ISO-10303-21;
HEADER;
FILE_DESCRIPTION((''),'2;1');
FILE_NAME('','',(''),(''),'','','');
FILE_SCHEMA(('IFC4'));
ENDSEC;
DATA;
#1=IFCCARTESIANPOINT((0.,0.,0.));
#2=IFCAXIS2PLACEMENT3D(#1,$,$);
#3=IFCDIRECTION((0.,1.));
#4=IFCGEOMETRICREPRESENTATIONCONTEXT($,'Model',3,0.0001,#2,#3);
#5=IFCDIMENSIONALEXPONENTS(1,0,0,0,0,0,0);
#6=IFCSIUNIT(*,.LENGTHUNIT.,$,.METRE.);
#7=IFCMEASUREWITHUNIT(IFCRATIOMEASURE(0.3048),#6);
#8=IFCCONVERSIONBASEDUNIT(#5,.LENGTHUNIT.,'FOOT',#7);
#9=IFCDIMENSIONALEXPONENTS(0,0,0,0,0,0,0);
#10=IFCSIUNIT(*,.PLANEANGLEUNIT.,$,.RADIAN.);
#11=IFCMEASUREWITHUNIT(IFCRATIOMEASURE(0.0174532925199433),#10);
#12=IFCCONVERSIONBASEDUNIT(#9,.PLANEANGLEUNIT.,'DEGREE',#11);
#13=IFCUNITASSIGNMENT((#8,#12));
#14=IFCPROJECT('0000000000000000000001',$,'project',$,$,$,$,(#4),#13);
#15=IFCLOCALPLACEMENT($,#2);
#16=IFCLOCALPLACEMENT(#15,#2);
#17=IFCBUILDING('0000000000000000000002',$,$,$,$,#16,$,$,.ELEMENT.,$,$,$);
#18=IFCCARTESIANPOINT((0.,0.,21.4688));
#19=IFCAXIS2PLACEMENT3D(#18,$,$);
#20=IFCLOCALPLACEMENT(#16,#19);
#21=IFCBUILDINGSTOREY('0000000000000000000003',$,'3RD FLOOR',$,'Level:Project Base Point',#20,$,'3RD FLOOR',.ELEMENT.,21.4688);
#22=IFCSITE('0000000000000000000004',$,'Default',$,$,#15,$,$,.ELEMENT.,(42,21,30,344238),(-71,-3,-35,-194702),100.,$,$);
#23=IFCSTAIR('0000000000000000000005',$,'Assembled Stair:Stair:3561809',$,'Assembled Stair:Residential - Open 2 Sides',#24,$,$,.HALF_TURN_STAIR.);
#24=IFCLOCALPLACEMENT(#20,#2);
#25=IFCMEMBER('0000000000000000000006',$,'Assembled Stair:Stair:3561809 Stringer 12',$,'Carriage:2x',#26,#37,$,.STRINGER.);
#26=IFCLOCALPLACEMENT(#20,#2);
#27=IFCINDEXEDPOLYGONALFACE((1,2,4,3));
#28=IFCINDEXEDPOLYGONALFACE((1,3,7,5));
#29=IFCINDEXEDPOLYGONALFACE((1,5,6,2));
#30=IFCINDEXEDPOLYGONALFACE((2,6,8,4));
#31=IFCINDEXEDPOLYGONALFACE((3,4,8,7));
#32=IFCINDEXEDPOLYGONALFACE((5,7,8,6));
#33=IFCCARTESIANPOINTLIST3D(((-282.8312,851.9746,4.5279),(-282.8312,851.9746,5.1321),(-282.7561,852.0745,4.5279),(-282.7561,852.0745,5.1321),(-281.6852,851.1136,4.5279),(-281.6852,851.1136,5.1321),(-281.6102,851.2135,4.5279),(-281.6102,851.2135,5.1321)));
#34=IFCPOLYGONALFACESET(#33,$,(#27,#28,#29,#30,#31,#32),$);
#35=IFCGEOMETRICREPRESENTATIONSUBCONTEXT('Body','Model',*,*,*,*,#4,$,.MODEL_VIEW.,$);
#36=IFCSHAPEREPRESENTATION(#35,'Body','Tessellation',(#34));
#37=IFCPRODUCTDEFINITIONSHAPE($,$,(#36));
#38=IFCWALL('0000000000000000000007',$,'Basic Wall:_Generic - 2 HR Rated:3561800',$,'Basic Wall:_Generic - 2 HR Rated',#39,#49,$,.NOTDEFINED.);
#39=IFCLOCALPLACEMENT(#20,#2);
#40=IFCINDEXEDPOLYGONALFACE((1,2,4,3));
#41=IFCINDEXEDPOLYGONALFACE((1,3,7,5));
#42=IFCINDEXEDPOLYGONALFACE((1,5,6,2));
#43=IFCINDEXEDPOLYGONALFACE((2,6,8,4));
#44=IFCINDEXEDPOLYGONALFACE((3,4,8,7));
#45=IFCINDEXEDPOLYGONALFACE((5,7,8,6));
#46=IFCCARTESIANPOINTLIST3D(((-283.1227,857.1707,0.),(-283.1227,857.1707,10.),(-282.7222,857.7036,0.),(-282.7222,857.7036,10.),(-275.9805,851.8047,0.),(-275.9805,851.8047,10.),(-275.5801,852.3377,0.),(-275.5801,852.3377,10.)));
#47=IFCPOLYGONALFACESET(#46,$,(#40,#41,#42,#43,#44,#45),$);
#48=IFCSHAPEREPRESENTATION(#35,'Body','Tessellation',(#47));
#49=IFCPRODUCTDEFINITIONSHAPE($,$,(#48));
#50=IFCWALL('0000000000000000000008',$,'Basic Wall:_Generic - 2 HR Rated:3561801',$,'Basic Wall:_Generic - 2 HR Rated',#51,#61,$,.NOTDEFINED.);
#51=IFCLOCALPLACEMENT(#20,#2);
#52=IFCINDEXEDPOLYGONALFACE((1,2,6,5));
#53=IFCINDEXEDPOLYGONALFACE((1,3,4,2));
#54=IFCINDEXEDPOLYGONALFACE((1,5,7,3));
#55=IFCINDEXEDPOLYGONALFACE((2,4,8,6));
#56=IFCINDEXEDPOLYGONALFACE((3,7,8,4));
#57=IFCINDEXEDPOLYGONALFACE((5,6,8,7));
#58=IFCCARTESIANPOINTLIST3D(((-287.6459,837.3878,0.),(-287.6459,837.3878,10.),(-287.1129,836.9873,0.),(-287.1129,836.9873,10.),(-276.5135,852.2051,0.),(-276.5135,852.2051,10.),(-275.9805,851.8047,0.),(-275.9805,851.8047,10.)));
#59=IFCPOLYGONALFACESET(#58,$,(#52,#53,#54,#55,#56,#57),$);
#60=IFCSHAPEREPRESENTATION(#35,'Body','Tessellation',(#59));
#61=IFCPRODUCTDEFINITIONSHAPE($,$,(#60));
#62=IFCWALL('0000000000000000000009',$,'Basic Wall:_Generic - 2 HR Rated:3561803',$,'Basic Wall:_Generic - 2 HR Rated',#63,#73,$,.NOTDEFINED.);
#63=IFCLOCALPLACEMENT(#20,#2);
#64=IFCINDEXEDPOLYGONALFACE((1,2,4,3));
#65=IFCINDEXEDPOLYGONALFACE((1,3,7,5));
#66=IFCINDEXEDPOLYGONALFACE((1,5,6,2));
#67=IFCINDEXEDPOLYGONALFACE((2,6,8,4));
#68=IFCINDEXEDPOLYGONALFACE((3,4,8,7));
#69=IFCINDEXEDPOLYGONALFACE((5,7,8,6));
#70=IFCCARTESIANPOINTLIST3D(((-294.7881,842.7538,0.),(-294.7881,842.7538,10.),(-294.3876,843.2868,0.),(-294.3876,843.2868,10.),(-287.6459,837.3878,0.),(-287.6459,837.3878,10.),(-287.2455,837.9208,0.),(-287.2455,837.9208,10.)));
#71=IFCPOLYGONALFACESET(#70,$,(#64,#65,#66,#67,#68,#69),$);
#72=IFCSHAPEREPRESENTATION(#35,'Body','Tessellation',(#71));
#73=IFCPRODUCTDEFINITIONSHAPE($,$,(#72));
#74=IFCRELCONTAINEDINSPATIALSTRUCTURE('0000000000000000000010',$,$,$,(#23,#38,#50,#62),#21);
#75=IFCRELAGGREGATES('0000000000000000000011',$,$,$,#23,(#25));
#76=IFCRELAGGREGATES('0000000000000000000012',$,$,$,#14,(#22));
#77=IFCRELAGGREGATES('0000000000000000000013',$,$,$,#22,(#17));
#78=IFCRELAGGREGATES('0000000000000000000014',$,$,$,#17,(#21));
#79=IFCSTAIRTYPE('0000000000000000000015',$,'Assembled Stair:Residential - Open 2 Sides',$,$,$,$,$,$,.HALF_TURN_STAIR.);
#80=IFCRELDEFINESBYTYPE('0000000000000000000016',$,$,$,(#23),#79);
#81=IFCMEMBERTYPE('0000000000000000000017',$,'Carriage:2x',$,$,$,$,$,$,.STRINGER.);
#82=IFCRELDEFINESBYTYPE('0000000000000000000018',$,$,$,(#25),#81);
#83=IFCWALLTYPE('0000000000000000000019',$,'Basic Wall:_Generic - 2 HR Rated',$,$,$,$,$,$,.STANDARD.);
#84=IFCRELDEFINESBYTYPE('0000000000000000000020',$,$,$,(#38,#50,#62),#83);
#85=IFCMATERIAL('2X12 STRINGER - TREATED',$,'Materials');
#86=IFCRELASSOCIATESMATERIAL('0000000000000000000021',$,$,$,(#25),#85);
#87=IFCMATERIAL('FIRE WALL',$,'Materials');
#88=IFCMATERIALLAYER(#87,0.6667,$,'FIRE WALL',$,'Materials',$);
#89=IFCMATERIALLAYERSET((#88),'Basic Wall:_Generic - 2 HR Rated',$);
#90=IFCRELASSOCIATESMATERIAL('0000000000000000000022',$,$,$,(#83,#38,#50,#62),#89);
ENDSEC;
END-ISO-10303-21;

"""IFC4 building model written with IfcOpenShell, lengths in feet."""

from ifc_helpers import new_model, entity, si_unit, converted_unit, direction, frame, frame_2d, origin, place, context, subcontext, project, spatial, rectangle, extrude, material, layer, layer_set, layer_usage, type_object, element, aggregate, save


model = new_model("IFC4")

# Units and contexts
model_context = context("Model", 3, precision=0.0001, world=origin(), true_north=direction((0.0, 1.0)))
body_context = subcontext(model_context, "Body", "Model", "MODEL_VIEW")
ifc_project = project(units=[converted_unit("LENGTHUNIT", "FOOT", entity("IfcRatioMeasure", 0.3048), si_unit("LENGTHUNIT", "METRE"), dimensions=[1, 0, 0, 0, 0, 0, 0]), converted_unit("PLANEANGLEUNIT", "DEGREE", entity("IfcRatioMeasure", 0.0174532925199433), si_unit("PLANEANGLEUNIT", "RADIAN"), dimensions=[0, 0, 0, 0, 0, 0, 0])], contexts=[model_context])

# Site, building, storey
site_placement = place(None, origin())
site = spatial("IfcSite", under=ifc_project, at=site_placement, Name="Default", CompositionType="ELEMENT", RefLatitude=(42, 21, 30, 344238), RefLongitude=(-71, -3, -35, -194702), RefElevation=100.0)
building_placement = place(site_placement, origin())
building = spatial("IfcBuilding", under=site, at=building_placement, CompositionType="ELEMENT")
storey_placement = place(building_placement, frame((0.0, 0.0, 21.4688)))
storey = spatial("IfcBuildingStorey", under=building, at=storey_placement, Name="3RD FLOOR", ObjectType="Level:Project Base Point", LongName="3RD FLOOR", CompositionType="ELEMENT", Elevation=21.4688)

# Shared definitions
ifc_material_1 = material(Name="2X12 STRINGER - TREATED", Category="Materials")
member_type = type_object("IfcMemberType", Name="Carriage:2x", PredefinedType="STRINGER")

# Stair, member
stair_type_1 = type_object("IfcStairType", Name="Assembled Stair:Residential - Open 2 Sides", PredefinedType="HALF_TURN_STAIR")
stair_1_placement = place(storey_placement, origin())
stair_1 = element("IfcStair", 1, at=stair_1_placement, inside=storey, type_object=stair_type_1, Name="Assembled Stair:Stair:3561809", ObjectType="Assembled Stair:Residential - Open 2 Sides", PredefinedType="HALF_TURN_STAIR")
member_1_placement = place(stair_1_placement, frame((-282.8312, 851.1136, 4.5279)))
member_1 = element("IfcMember", 2, at=member_1_placement, type_object=member_type, material=ifc_material_1, Name="Assembled Stair:Stair:3561809 Stringer 12", ObjectType="Carriage:2x", PredefinedType="STRINGER", context=body_context, shape_type="SweptSolid", body=[
    extrude(rectangle(XDim=0.125, YDim=1.4333, at=frame_2d((0.0, 0.0), x_axis=(1.0, 0.0))), frame((0.6105, 0.4804, 0.0), z_axis=(0.0, 0.0, 1.0), x_axis=(-0.60067, -0.799497, 0.0)), (0.0, 0.0, 1.0), 0.6042),
])

# Walls
ifc_material_2 = material(Name="FIRE WALL", Category="Materials")
ifc_layer = layer(ifc_material_2, 0.6667, Name="FIRE WALL", Category="Materials")
ifc_layer_set = layer_set([ifc_layer], Name="Basic Wall:_Generic - 2 HR Rated")
ifc_layer_usage_1 = layer_usage(ifc_layer_set, "AXIS2", "NEGATIVE", 0.3333)
wall_type = type_object("IfcWallType", Name="Basic Wall:_Generic - 2 HR Rated", PredefinedType="STANDARD", material=ifc_layer_set)
wall_1_placement = place(storey_placement, frame((-282.9225, 857.4372, 0.0), z_axis=(0.0, 0.0, 1.0), x_axis=(0.799497, -0.60067, 0.0)))
element("IfcWall", 3, at=wall_1_placement, inside=storey, type_object=wall_type, material=ifc_layer_usage_1, Name="Basic Wall:_Generic - 2 HR Rated:3561800", ObjectType="Basic Wall:_Generic - 2 HR Rated", PredefinedType="NOTDEFINED", context=body_context, shape_type="SweptSolid", body=[
    extrude(rectangle(XDim=8.9333, YDim=0.6667, at=frame_2d((4.4667, 0.0), x_axis=(-1.0, 0.0))), origin(), (0.0, 0.0, 1.0), 10.0),
])
ifc_layer_usage_2 = layer_usage(ifc_layer_set, "AXIS2", "NEGATIVE", 0.3333)
wall_2_placement = place(storey_placement, frame((-276.247, 852.0049, 0.0), z_axis=(0.0, 0.0, 1.0), x_axis=(-0.60067, -0.799497, 0.0)))
element("IfcWall", 4, at=wall_2_placement, inside=storey, type_object=wall_type, material=ifc_layer_usage_2, Name="Basic Wall:_Generic - 2 HR Rated:3561801", ObjectType="Basic Wall:_Generic - 2 HR Rated", PredefinedType="NOTDEFINED", context=body_context, shape_type="SweptSolid", body=[
    extrude(rectangle(XDim=18.5333, YDim=0.6667, at=frame_2d((9.2667, 0.0), x_axis=(-1.0, 0.0))), origin(), (0.0, 0.0, 1.0), 10.0),
])
ifc_layer_usage_3 = layer_usage(ifc_layer_set, "AXIS2", "NEGATIVE", 0.3333)
wall_3_placement = place(storey_placement, frame((-287.4457, 837.6543, 0.0), z_axis=(0.0, 0.0, 1.0), x_axis=(-0.799497, 0.60067, 0.0)))
element("IfcWall", 5, at=wall_3_placement, inside=storey, type_object=wall_type, material=ifc_layer_usage_3, Name="Basic Wall:_Generic - 2 HR Rated:3561803", ObjectType="Basic Wall:_Generic - 2 HR Rated", PredefinedType="NOTDEFINED", context=body_context, shape_type="SweptSolid", body=[
    extrude(rectangle(XDim=8.9333, YDim=0.6667, at=frame_2d((4.4667, 0.0), x_axis=(-1.0, 0.0))), origin(), (0.0, 0.0, 1.0), 10.0),
])

aggregate(stair_1, [member_1])

save(model, "model.ifc")
